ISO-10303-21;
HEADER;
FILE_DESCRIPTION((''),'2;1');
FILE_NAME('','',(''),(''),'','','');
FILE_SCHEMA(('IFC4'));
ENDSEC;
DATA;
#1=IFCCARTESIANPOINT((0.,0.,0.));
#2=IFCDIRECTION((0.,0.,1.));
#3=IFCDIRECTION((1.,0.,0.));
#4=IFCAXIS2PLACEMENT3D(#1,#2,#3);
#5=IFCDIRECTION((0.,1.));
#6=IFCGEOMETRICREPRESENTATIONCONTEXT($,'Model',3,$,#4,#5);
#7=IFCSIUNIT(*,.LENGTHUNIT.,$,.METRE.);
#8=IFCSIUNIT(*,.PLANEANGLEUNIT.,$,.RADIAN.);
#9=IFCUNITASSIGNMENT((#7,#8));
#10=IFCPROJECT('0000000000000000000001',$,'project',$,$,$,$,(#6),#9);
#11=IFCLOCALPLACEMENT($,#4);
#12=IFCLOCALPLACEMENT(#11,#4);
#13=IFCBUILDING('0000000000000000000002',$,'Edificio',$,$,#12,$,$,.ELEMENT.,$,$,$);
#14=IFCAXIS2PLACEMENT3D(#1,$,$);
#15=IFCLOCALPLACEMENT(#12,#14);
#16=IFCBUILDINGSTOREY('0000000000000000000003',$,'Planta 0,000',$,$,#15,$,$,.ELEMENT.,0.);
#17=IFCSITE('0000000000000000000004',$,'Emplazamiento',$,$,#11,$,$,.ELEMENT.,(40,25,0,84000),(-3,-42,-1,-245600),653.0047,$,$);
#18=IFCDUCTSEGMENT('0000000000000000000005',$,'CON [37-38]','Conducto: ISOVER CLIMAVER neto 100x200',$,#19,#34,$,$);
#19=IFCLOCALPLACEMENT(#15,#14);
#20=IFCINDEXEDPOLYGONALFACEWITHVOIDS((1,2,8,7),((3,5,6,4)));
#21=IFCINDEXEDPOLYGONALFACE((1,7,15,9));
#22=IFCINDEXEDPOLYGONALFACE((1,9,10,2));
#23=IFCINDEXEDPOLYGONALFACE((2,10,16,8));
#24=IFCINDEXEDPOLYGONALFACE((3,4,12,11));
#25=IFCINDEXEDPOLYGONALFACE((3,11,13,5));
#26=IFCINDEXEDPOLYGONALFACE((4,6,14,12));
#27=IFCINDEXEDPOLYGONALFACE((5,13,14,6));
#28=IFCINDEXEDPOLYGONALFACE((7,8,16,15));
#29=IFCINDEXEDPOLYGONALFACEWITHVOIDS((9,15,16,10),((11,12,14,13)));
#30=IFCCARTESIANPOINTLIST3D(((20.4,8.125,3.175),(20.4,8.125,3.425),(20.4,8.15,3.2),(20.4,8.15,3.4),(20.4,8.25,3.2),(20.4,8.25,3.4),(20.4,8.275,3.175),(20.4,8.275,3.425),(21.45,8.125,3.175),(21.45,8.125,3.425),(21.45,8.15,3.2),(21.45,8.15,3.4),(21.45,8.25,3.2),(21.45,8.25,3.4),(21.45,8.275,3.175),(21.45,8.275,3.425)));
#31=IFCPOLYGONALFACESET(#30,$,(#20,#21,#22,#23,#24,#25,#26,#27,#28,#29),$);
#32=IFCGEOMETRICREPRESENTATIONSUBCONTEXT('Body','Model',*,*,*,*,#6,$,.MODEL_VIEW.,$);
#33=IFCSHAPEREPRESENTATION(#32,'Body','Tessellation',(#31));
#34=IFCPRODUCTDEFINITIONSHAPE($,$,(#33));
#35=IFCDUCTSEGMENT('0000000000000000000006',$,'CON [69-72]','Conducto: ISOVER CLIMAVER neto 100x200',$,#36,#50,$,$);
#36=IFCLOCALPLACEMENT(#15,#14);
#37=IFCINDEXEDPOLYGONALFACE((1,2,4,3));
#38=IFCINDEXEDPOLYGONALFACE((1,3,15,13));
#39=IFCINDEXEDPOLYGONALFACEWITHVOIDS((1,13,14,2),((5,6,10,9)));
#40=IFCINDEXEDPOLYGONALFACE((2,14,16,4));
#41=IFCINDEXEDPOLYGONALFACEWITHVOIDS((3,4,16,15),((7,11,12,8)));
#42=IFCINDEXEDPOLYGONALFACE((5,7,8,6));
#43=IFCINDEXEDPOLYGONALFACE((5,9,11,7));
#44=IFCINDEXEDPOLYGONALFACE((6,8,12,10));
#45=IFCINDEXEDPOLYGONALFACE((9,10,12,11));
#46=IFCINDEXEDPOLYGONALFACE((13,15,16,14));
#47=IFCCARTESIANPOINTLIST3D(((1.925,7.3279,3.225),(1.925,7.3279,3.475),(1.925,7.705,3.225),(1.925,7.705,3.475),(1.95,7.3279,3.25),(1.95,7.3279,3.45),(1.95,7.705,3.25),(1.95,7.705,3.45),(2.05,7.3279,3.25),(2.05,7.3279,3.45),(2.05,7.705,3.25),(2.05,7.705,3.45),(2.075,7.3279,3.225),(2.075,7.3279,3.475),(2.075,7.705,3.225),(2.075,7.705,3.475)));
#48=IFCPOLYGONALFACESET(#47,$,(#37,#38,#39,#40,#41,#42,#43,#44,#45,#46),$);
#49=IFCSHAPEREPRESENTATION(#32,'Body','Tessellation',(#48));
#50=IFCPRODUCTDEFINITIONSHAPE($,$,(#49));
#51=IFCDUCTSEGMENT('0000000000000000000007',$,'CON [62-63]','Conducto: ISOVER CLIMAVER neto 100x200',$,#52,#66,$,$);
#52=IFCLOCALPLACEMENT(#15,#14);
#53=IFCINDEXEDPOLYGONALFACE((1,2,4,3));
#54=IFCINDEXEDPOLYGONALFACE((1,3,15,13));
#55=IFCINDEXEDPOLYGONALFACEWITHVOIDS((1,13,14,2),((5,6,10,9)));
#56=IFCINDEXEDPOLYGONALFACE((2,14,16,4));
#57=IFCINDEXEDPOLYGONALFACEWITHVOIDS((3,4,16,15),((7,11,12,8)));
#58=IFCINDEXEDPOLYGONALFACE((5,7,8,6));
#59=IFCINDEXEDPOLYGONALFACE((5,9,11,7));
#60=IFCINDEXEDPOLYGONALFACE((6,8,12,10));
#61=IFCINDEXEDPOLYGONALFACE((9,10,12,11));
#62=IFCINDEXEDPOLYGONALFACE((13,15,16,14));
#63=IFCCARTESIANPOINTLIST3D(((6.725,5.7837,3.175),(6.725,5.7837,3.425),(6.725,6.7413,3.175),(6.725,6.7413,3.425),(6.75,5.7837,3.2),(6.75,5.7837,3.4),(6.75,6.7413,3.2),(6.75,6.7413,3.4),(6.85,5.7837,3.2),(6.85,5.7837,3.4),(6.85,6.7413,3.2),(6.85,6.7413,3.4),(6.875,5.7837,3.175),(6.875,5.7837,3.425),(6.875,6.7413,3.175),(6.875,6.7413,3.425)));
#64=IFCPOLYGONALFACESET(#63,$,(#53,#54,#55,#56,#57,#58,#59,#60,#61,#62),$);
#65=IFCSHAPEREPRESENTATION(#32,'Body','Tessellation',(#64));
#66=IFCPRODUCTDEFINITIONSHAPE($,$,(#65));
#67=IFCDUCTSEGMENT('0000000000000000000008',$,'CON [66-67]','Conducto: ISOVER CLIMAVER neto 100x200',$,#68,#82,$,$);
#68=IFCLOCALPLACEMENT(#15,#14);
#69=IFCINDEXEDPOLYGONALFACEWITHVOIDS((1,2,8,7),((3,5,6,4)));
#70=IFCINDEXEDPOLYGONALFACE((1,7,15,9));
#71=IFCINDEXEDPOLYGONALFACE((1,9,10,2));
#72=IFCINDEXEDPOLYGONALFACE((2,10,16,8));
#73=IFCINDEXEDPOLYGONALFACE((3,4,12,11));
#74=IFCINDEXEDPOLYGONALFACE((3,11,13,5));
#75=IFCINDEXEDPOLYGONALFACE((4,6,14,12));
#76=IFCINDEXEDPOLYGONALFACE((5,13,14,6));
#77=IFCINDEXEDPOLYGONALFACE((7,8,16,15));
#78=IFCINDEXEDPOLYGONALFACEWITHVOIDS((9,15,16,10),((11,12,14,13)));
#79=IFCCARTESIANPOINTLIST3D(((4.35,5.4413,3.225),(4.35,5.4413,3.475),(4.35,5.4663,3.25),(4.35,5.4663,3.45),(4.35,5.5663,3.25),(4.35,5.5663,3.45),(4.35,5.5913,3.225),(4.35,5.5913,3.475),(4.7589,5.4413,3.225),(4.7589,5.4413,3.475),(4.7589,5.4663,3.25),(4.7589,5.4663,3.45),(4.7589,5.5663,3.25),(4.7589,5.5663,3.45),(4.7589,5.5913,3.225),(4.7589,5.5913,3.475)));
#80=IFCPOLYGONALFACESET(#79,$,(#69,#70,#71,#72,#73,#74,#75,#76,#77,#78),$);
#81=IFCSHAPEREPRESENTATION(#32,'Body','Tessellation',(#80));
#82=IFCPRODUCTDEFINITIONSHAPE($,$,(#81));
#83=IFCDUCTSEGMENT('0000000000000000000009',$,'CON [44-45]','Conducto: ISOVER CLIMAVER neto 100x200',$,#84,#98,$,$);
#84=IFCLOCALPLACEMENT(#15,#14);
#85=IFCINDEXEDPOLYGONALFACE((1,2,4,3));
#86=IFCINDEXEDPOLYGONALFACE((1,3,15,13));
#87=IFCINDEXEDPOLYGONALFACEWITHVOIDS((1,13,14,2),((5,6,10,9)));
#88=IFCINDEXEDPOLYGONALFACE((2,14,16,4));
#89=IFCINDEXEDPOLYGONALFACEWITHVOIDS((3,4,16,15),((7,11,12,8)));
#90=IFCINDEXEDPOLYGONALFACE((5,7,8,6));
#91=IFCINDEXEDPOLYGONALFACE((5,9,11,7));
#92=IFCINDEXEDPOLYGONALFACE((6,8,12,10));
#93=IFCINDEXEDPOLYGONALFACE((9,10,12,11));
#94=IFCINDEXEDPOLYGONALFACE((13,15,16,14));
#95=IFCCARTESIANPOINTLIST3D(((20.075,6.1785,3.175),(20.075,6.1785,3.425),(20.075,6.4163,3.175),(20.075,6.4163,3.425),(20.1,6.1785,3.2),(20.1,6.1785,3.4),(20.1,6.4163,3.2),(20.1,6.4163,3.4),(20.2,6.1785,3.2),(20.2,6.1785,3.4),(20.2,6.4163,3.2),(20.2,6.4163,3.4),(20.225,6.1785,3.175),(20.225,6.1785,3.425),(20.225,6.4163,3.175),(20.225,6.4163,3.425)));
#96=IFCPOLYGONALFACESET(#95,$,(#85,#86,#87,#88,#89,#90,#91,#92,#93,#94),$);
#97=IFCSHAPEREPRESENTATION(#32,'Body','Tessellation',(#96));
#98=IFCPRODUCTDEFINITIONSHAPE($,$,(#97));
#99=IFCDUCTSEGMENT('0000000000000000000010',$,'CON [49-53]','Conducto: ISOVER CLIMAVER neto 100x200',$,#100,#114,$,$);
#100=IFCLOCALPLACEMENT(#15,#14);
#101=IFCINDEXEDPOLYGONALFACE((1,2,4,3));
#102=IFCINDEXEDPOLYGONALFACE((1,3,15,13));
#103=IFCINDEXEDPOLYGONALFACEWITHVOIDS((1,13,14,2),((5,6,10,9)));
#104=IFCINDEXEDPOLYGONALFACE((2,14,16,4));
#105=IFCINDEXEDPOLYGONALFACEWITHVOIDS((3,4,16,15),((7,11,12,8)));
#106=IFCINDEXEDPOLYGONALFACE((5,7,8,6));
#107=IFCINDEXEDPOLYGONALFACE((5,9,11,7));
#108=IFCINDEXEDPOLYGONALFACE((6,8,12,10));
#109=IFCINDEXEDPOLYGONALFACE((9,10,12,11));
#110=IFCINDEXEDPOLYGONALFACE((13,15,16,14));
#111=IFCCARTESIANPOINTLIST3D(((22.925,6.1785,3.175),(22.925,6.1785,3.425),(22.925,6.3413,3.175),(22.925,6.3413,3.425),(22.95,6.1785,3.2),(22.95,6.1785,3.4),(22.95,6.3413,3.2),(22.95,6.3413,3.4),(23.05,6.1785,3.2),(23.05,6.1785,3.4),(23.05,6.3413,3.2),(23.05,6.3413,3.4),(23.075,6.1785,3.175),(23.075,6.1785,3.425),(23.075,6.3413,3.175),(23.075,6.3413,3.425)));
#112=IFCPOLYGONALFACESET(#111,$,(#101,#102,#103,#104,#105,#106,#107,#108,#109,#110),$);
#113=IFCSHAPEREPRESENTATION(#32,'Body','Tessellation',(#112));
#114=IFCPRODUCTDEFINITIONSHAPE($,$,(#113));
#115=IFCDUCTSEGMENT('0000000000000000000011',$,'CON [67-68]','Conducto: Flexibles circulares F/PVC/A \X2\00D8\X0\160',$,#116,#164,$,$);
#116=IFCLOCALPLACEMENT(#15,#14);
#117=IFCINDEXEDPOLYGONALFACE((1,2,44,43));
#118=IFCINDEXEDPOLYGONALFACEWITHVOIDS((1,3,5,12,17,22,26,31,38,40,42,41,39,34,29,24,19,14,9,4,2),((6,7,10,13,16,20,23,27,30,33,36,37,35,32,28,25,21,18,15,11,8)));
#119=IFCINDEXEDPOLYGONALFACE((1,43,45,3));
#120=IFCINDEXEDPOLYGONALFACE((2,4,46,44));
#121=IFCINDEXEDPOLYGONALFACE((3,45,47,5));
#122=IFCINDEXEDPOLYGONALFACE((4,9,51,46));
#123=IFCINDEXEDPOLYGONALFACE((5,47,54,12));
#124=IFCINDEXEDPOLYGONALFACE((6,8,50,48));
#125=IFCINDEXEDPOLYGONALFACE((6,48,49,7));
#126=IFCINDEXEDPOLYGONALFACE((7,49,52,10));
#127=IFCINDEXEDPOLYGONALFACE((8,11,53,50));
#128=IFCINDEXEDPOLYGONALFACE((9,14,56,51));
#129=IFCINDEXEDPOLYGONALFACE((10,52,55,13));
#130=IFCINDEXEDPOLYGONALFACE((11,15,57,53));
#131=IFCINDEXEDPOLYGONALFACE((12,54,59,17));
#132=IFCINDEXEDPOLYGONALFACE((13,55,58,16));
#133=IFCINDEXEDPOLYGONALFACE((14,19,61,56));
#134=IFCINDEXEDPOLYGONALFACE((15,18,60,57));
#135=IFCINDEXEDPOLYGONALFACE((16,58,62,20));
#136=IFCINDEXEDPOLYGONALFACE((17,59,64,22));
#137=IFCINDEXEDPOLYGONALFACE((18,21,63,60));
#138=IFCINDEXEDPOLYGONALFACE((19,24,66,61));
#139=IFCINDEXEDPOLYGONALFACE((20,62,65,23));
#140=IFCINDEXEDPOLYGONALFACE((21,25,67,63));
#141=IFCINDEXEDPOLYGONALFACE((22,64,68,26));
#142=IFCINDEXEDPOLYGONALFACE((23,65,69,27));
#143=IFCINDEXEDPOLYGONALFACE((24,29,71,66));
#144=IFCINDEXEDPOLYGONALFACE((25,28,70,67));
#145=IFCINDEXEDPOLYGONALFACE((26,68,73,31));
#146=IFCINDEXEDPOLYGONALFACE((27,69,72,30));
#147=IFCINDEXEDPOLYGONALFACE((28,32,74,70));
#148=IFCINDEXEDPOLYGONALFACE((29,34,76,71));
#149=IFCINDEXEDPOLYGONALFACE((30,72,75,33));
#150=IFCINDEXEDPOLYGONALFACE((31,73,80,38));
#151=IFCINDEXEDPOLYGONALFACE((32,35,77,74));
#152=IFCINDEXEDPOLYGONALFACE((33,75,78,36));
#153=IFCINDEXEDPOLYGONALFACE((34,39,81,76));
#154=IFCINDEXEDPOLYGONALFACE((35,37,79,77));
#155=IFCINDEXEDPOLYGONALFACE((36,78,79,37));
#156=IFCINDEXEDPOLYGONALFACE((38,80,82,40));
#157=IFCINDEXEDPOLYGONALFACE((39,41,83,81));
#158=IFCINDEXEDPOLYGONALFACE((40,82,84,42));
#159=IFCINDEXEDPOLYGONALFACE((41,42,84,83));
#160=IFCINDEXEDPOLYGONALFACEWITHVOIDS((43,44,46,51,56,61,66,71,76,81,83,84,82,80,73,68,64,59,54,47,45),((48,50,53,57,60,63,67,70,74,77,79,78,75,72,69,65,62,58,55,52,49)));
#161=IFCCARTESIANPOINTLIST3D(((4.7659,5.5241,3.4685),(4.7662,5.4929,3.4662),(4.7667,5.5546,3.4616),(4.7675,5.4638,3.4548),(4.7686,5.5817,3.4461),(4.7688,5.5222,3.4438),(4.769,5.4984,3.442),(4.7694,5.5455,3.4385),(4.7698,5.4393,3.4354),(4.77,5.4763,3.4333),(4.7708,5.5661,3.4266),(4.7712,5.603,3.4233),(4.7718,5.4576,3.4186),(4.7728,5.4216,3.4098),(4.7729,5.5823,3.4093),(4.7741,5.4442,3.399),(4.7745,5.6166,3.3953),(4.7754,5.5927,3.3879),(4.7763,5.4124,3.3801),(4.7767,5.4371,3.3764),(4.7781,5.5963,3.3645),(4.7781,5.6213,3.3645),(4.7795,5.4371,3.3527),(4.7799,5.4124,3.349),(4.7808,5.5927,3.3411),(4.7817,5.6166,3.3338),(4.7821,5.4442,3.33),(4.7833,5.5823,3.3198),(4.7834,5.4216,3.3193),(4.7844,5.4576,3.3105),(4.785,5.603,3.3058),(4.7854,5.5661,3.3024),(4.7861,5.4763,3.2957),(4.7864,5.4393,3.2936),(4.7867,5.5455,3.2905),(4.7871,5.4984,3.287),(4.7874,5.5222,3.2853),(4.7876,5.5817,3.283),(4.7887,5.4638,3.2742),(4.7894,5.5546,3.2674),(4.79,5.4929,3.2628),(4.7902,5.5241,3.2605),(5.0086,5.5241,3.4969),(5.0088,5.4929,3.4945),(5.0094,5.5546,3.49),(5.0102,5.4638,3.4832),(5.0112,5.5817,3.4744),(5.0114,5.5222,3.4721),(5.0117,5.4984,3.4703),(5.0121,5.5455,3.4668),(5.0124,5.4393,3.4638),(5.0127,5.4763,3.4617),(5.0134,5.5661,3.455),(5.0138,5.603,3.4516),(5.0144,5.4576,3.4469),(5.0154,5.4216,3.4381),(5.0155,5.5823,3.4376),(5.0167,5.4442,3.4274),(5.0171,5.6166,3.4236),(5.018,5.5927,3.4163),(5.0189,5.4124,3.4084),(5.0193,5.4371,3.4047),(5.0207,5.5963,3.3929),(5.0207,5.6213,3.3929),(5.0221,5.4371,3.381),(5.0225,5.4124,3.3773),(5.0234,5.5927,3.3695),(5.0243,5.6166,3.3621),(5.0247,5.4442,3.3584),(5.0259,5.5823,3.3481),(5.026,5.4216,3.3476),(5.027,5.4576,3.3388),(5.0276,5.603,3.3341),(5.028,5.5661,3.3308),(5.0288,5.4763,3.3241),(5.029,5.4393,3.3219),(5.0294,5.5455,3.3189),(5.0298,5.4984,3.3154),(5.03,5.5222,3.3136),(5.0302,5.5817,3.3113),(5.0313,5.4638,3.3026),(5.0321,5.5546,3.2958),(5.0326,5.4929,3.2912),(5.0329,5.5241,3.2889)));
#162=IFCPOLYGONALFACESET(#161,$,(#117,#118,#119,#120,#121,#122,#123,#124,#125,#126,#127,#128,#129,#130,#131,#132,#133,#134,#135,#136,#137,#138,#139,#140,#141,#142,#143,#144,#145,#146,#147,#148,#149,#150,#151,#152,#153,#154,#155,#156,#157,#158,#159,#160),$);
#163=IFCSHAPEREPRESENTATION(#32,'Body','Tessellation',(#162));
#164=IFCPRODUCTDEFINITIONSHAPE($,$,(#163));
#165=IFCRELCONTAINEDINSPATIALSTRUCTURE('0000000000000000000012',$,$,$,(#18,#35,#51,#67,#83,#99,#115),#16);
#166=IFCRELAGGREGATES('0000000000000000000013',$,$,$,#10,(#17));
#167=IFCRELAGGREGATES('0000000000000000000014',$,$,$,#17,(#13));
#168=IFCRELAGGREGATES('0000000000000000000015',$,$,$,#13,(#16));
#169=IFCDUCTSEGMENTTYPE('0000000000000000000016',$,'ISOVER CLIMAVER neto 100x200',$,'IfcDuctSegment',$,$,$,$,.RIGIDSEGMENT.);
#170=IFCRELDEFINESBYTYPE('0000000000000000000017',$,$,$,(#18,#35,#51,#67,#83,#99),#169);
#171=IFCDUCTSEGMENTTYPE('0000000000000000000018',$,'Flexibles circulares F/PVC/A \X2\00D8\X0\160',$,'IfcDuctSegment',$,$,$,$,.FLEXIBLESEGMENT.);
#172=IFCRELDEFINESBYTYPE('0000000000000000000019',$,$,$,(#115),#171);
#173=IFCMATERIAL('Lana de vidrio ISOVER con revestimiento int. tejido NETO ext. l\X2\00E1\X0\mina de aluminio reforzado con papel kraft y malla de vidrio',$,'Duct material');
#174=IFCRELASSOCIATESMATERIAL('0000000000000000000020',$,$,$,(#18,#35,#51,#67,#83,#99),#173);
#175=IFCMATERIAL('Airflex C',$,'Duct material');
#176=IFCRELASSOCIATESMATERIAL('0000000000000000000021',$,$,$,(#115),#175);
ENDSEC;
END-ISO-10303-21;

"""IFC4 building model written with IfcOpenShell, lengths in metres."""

from ifc_helpers import new_model, si_unit, direction, frame, origin, origin_with_axes, origin_2d_with_axis, place, context, subcontext, project, spatial, hollow_rectangle, hollow_circle, extrude, material, type_object, element, save


model = new_model("IFC4")

# Units and contexts
model_context = context("Model", 3, world=origin_with_axes(), true_north=direction((0.0, 1.0)))
body_context = subcontext(model_context, "Body", "Model", "MODEL_VIEW")
ifc_project = project(units=[si_unit("LENGTHUNIT", "METRE"), si_unit("PLANEANGLEUNIT", "RADIAN")], contexts=[model_context])

# Site, building, storey
site_placement = place(None, origin_with_axes())
site = spatial("IfcSite", under=ifc_project, at=site_placement, Name="Emplazamiento", CompositionType="ELEMENT", RefLatitude=(40, 25, 0, 84000), RefLongitude=(-3, -42, -1, -245600), RefElevation=653.0047)
building_placement = place(site_placement, origin_with_axes())
building = spatial("IfcBuilding", under=site, at=building_placement, Name="Edificio", CompositionType="ELEMENT")
storey_placement = place(building_placement, origin())
storey = spatial("IfcBuildingStorey", under=building, at=storey_placement, Name="Planta 0,000", CompositionType="ELEMENT", Elevation=0.0)

# Duct segments
ifc_material_1 = material(Name="Lana de vidrio ISOVER con revestimiento int. tejido NETO ext. lámina de aluminio reforzado con papel kraft y malla de vidrio", Category="Duct material")
duct_segment_type_1 = type_object("IfcDuctSegmentType", Name="ISOVER CLIMAVER neto 100x200", ApplicableOccurrence="IfcDuctSegment", PredefinedType="RIGIDSEGMENT")
duct_segment_1_placement = place(storey_placement, origin_with_axes())
element("IfcDuctSegment", 1, at=duct_segment_1_placement, inside=storey, type_object=duct_segment_type_1, material=ifc_material_1, Name="CON [37-38]", Description="Conducto: ISOVER CLIMAVER neto 100x200", context=body_context, shape_type="SweptSolid", body=[
    extrude(hollow_rectangle(XDim=0.15, YDim=0.25, WallThickness=0.025, at=origin_2d_with_axis()), frame((20.4, 8.2, 3.3), z_axis=(1.0, 0.0, 0.0), x_axis=(0.0, 1.0, 0.0)), (0.0, 0.0, 1.0), 1.05),
])
duct_segment_2_placement = place(storey_placement, origin_with_axes())
element("IfcDuctSegment", 2, at=duct_segment_2_placement, inside=storey, type_object=duct_segment_type_1, material=ifc_material_1, Name="CON [69-72]", Description="Conducto: ISOVER CLIMAVER neto 100x200", context=body_context, shape_type="SweptSolid", body=[
    extrude(hollow_rectangle(XDim=0.15, YDim=0.25, WallThickness=0.025, at=origin_2d_with_axis()), frame((2.0, 7.3279, 3.35), z_axis=(0.0, 1.0, 0.0), x_axis=(-1.0, 0.0, 0.0)), (0.0, 0.0, 1.0), 0.3771),
])
duct_segment_3_placement = place(storey_placement, origin_with_axes())
element("IfcDuctSegment", 3, at=duct_segment_3_placement, inside=storey, type_object=duct_segment_type_1, material=ifc_material_1, Name="CON [62-63]", Description="Conducto: ISOVER CLIMAVER neto 100x200", context=body_context, shape_type="SweptSolid", body=[
    extrude(hollow_rectangle(XDim=0.15, YDim=0.25, WallThickness=0.025, at=origin_2d_with_axis()), frame((6.8, 6.7413, 3.3), z_axis=(0.0, -1.0, 0.0), x_axis=(1.0, 0.0, 0.0)), (0.0, 0.0, 1.0), 0.9575),
])
duct_segment_4_placement = place(storey_placement, origin_with_axes())
element("IfcDuctSegment", 4, at=duct_segment_4_placement, inside=storey, type_object=duct_segment_type_1, material=ifc_material_1, Name="CON [66-67]", Description="Conducto: ISOVER CLIMAVER neto 100x200", context=body_context, shape_type="SweptSolid", body=[
    extrude(hollow_rectangle(XDim=0.15, YDim=0.25, WallThickness=0.025, at=origin_2d_with_axis()), frame((4.35, 5.5163, 3.35), z_axis=(1.0, 0.0, 0.0), x_axis=(0.0, 1.0, 0.0)), (0.0, 0.0, 1.0), 0.4089),
])
duct_segment_5_placement = place(storey_placement, origin_with_axes())
element("IfcDuctSegment", 5, at=duct_segment_5_placement, inside=storey, type_object=duct_segment_type_1, material=ifc_material_1, Name="CON [44-45]", Description="Conducto: ISOVER CLIMAVER neto 100x200", context=body_context, shape_type="SweptSolid", body=[
    extrude(hollow_rectangle(XDim=0.15, YDim=0.25, WallThickness=0.025, at=origin_2d_with_axis()), frame((20.15, 6.4163, 3.3), z_axis=(0.0, -1.0, 0.0), x_axis=(1.0, 0.0, 0.0)), (0.0, 0.0, 1.0), 0.2378),
])
duct_segment_6_placement = place(storey_placement, origin_with_axes())
element("IfcDuctSegment", 6, at=duct_segment_6_placement, inside=storey, type_object=duct_segment_type_1, material=ifc_material_1, Name="CON [49-53]", Description="Conducto: ISOVER CLIMAVER neto 100x200", context=body_context, shape_type="SweptSolid", body=[
    extrude(hollow_rectangle(XDim=0.15, YDim=0.25, WallThickness=0.025, at=origin_2d_with_axis()), frame((23.0, 6.3413, 3.3), z_axis=(0.0, -1.0, 0.0), x_axis=(1.0, 0.0, 0.0)), (0.0, 0.0, 1.0), 0.1628),
])
ifc_material_2 = material(Name="Airflex C", Category="Duct material")
duct_segment_type_2 = type_object("IfcDuctSegmentType", Name="Flexibles circulares F/PVC/A Ø160", ApplicableOccurrence="IfcDuctSegment", PredefinedType="FLEXIBLESEGMENT")
duct_segment_7_placement = place(storey_placement, origin_with_axes())
element("IfcDuctSegment", 7, at=duct_segment_7_placement, inside=storey, type_object=duct_segment_type_2, material=ifc_material_2, Name="CON [67-68]", Description="Conducto: Flexibles circulares F/PVC/A Ø160", context=body_context, shape_type="SweptSolid", body=[
    extrude(hollow_circle(Radius=0.105, WallThickness=0.025, at=origin_2d_with_axis()), frame((4.7781, 5.5163, 3.3645), z_axis=(0.993237, 0.0, 0.116107), x_axis=(0.0, 1.0, 0.0)), (0.0, 0.0, 1.0), 0.2443),
])

save(model, "model.ifc")
